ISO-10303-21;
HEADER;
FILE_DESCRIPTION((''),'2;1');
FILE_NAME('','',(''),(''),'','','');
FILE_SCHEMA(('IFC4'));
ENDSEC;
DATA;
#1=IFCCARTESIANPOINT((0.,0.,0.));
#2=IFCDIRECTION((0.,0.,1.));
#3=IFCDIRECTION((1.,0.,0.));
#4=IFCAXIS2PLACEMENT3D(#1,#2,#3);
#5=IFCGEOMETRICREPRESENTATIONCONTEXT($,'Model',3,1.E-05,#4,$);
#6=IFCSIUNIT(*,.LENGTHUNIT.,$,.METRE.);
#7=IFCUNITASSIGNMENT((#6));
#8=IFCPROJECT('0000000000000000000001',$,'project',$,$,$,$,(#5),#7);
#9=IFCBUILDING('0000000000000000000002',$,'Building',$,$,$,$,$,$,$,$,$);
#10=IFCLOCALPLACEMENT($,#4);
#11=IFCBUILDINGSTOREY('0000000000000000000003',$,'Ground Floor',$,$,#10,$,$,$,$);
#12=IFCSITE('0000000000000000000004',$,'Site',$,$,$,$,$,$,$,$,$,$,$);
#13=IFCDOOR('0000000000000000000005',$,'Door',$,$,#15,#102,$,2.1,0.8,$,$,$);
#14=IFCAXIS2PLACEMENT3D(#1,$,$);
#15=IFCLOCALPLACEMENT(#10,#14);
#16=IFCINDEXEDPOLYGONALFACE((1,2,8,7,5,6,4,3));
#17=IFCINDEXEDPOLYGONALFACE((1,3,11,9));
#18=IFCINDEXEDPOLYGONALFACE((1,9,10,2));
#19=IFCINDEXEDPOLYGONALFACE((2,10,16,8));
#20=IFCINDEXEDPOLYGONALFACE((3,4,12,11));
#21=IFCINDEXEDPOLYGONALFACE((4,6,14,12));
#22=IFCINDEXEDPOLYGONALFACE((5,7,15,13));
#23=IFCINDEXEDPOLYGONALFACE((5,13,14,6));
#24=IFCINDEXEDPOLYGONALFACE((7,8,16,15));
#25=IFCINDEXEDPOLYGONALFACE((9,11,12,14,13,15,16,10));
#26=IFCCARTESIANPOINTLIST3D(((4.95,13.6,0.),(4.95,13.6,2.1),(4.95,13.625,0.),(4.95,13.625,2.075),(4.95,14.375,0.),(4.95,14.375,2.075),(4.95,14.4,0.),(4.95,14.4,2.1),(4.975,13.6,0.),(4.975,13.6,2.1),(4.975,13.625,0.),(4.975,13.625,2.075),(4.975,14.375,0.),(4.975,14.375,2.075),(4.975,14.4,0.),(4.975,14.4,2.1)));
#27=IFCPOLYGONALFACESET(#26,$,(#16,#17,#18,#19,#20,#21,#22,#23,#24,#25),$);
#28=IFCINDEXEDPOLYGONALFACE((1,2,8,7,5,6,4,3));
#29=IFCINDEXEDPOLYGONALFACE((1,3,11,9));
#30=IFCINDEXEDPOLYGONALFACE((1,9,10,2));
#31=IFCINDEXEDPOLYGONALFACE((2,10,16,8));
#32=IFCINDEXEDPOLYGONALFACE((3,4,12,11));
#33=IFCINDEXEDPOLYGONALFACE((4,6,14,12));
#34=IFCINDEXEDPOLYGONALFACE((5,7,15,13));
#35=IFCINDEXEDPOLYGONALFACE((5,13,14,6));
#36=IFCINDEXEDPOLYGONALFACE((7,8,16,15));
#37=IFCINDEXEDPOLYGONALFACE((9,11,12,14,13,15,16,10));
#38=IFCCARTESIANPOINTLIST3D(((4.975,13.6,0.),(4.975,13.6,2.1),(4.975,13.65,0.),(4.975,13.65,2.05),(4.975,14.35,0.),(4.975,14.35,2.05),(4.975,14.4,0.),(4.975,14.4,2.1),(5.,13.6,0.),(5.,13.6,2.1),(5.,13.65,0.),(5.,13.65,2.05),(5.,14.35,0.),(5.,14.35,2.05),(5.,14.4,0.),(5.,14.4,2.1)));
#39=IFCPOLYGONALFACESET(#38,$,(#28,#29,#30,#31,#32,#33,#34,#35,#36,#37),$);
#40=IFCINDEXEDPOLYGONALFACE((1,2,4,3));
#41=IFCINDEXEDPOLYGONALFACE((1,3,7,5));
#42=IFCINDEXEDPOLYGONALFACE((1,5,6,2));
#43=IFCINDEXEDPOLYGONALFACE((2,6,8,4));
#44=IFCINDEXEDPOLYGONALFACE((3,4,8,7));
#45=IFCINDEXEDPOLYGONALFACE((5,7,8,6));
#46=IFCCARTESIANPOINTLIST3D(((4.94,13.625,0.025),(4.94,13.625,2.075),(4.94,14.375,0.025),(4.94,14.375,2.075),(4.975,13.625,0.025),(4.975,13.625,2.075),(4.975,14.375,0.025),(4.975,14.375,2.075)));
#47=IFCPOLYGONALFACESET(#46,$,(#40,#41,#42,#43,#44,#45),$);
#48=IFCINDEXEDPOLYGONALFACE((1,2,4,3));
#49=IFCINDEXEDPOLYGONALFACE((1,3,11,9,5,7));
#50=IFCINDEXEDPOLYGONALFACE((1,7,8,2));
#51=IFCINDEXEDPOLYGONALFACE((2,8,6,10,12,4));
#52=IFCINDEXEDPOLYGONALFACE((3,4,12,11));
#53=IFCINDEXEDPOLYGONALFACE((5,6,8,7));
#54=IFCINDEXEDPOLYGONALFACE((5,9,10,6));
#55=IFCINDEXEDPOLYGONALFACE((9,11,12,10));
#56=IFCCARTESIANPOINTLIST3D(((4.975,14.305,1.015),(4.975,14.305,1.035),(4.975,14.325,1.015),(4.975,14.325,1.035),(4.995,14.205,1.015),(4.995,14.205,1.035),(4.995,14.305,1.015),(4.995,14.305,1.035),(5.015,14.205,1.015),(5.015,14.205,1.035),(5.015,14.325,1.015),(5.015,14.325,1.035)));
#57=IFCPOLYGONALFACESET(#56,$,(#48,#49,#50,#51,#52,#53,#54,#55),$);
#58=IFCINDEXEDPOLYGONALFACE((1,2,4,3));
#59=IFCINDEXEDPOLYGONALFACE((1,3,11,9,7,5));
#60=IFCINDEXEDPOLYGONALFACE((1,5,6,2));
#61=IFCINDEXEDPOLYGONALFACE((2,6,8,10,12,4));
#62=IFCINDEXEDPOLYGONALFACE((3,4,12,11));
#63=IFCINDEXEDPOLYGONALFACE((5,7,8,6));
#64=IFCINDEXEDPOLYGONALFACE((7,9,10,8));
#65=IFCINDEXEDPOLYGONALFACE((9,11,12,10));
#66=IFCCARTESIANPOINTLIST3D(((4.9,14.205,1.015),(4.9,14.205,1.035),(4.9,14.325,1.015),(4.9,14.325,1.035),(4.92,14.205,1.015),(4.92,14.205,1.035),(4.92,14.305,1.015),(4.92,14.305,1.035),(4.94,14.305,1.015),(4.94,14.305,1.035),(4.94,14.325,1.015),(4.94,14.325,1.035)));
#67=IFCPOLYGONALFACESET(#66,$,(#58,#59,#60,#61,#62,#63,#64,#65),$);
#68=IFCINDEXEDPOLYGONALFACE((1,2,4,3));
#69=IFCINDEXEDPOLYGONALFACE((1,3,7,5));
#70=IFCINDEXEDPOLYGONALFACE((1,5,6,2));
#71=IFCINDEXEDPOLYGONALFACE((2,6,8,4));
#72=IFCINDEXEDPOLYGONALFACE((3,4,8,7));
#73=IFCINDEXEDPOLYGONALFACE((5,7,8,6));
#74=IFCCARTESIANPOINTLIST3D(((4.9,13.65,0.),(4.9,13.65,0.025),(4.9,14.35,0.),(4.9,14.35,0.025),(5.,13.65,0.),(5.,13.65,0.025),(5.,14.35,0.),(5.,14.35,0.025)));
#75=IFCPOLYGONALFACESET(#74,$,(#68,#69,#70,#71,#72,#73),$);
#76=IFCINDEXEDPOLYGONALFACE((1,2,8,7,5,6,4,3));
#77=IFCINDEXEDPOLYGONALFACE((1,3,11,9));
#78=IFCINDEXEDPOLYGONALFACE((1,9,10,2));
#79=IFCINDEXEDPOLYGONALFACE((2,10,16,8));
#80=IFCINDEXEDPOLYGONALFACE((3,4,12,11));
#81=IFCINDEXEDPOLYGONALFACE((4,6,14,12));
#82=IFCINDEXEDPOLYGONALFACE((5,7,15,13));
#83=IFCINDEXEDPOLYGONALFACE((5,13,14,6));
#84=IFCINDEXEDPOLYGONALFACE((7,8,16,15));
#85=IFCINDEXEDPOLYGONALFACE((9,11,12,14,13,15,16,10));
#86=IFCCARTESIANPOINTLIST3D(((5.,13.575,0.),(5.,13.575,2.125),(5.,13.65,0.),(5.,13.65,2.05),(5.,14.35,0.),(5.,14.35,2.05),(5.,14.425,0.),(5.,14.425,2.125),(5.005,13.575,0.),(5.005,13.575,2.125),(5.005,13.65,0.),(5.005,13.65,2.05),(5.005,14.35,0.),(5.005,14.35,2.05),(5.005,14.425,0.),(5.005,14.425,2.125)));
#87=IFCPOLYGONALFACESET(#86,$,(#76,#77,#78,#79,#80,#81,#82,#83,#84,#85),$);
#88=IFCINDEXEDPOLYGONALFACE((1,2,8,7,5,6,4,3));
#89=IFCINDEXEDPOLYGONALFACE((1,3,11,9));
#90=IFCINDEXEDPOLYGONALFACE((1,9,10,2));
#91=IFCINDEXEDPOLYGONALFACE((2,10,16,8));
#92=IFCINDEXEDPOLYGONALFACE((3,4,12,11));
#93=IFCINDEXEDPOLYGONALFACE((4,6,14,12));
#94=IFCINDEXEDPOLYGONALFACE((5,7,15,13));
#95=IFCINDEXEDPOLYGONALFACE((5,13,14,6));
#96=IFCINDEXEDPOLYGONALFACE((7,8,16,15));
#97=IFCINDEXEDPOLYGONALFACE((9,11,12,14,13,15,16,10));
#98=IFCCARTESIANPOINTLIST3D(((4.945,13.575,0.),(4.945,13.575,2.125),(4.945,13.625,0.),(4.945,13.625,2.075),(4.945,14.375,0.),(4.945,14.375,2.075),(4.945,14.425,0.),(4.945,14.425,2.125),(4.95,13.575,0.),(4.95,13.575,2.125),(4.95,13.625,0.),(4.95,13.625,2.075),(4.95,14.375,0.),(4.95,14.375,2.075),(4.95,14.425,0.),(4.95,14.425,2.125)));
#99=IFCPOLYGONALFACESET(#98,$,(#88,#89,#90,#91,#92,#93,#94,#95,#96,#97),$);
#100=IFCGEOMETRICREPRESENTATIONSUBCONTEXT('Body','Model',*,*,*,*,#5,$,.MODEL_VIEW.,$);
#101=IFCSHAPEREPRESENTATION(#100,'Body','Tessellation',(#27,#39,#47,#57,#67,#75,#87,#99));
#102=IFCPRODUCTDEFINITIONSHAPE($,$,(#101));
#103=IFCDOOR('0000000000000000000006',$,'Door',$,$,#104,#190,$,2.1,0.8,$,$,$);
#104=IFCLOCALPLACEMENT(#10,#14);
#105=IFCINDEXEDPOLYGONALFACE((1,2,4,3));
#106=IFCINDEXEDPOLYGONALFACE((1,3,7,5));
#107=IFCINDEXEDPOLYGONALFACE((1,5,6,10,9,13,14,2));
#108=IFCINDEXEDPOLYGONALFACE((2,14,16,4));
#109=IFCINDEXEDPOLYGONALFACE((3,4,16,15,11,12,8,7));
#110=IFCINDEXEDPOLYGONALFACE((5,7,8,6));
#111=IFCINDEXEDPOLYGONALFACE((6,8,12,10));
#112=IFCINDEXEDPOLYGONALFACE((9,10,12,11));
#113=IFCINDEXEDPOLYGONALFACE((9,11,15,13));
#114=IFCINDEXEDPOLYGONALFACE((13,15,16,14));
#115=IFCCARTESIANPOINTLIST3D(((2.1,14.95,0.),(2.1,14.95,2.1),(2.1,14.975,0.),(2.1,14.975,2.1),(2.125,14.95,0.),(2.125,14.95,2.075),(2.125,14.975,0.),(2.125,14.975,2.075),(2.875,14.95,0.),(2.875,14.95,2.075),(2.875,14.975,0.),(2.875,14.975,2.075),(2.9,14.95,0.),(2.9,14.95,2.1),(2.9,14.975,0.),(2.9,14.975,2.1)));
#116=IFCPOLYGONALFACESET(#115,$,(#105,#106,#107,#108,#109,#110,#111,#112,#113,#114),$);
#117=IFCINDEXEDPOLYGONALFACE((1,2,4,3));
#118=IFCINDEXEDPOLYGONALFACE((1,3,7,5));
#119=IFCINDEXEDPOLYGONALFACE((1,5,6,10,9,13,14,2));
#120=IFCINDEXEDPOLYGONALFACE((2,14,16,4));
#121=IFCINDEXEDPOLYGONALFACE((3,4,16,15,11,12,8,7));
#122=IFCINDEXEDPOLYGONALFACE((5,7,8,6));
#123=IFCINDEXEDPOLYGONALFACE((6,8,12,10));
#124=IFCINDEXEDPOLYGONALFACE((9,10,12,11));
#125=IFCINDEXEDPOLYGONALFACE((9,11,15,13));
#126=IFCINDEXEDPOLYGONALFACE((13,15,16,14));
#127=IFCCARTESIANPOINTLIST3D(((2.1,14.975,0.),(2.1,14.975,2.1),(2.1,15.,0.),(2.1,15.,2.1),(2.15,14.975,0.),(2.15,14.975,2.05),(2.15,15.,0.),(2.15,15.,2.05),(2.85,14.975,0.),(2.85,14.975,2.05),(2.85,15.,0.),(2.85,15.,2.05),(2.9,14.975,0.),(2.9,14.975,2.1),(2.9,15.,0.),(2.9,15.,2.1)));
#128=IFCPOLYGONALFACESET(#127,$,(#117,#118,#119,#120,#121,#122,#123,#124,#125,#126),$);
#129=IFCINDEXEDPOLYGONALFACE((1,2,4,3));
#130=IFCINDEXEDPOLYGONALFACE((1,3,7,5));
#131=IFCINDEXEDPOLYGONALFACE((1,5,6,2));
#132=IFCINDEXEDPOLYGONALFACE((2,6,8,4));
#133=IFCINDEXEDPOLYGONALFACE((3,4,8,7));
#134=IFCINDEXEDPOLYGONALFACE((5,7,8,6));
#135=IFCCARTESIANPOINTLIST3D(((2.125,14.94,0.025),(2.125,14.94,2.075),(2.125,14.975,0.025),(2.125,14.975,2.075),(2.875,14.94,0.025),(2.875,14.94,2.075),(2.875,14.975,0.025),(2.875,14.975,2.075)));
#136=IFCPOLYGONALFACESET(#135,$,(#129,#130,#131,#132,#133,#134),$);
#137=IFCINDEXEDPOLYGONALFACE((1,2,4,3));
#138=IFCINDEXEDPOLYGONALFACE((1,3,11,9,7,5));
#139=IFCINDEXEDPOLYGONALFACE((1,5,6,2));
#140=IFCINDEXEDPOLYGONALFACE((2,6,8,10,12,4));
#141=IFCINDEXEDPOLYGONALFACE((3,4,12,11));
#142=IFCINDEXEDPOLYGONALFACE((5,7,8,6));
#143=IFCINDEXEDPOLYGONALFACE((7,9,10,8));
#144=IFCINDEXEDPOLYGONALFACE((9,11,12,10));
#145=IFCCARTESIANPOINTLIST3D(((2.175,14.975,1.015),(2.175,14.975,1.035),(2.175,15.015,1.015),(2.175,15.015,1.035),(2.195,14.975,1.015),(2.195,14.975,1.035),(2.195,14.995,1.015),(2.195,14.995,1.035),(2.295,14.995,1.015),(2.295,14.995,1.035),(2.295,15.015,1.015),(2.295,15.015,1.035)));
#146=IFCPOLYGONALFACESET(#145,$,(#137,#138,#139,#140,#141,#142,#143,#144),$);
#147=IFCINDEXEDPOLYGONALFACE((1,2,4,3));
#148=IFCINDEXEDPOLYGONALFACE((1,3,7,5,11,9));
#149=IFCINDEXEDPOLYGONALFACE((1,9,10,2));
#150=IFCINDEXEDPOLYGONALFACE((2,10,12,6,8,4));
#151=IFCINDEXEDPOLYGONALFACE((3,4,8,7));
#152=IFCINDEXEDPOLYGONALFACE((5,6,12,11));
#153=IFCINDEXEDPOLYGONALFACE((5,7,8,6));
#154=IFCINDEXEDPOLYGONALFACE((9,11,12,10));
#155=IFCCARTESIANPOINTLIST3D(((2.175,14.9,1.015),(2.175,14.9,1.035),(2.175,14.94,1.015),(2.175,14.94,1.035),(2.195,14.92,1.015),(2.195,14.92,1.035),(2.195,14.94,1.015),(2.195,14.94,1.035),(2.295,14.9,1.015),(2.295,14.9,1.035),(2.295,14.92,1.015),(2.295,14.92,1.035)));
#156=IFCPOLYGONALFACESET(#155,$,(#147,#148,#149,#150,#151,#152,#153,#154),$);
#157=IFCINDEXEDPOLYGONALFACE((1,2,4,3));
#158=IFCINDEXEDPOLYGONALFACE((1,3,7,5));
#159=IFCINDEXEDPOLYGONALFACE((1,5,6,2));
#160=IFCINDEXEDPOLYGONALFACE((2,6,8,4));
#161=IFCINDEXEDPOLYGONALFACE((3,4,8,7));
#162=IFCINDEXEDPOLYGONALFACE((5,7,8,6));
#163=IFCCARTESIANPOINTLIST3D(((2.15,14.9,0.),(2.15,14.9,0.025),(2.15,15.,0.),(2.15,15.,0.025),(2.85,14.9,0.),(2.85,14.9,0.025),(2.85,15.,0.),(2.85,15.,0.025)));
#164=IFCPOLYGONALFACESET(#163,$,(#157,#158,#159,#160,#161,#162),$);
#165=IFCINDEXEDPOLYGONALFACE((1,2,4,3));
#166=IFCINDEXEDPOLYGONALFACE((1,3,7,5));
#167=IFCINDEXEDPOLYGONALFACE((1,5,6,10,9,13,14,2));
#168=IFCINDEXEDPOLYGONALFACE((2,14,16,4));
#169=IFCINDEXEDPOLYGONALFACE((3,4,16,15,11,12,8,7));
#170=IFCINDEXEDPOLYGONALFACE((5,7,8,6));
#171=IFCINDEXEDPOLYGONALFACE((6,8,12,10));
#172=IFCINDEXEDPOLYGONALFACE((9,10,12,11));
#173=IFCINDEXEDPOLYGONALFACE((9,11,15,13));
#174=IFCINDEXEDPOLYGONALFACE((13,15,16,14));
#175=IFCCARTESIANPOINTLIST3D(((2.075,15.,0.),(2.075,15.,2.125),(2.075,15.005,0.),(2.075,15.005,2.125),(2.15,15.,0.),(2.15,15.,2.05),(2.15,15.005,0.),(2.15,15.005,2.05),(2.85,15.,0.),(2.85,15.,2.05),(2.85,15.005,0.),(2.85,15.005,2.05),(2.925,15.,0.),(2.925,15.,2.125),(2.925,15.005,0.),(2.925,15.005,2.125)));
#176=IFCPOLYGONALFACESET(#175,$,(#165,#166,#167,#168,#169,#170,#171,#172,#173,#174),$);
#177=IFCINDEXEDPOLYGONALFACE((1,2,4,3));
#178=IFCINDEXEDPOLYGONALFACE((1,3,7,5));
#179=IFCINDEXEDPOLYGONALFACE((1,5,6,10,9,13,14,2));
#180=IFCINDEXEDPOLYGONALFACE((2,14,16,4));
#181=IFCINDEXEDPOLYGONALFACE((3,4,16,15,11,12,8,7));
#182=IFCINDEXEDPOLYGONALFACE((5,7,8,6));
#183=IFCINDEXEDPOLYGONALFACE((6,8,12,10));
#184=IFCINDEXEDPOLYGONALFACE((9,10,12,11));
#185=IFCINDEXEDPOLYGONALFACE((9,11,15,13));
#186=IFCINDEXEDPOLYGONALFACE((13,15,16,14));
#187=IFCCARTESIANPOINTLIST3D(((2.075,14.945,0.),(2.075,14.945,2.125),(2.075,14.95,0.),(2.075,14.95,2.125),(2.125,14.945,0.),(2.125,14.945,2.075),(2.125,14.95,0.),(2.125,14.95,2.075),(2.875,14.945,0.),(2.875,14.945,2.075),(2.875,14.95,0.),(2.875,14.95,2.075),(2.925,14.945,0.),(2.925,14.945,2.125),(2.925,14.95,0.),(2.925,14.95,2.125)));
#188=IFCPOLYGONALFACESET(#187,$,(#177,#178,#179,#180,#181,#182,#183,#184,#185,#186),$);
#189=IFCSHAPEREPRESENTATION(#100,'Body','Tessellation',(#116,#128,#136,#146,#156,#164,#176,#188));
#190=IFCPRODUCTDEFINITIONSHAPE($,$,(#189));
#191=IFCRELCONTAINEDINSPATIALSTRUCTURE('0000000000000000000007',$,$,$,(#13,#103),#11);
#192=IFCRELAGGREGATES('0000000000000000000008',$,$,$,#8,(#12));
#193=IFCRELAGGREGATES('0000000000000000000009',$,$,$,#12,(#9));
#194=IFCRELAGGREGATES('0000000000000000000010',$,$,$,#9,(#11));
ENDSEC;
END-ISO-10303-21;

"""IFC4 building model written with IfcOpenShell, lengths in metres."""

from ifc_helpers import new_model, si_unit, frame, origin_with_axes, place, context, subcontext, project, spatial, line, indexed_curve, outline, extrude, element, save


model = new_model("IFC4")

# Units and contexts
model_context = context("Model", 3, precision=1e-05, world=origin_with_axes())
body_context = subcontext(model_context, "Body", "Model", "MODEL_VIEW")
ifc_project = project(units=[si_unit("LENGTHUNIT", "METRE")], contexts=[model_context])

# Site, building, storey
site = spatial("IfcSite", under=ifc_project, Name="Site")
building = spatial("IfcBuilding", under=site, Name="Building")
storey_placement = place(None, origin_with_axes())
storey = spatial("IfcBuildingStorey", under=building, at=storey_placement, Name="Ground Floor")

# Doors
door_1_placement = place(storey_placement, frame((5.0, 13.6, 0.0), z_axis=(0.0, 0.0, 1.0), x_axis=(0.0, 1.0, 0.0)))
element("IfcDoor", 1, at=door_1_placement, inside=storey, Name="Door", OverallHeight=2.1, OverallWidth=0.8, context=body_context, shape_type="SweptSolid", body=[
    extrude(outline(indexed_curve([(0.0, 0.0), (0.0, 2.1), (0.8, 2.1), (0.8, 0.0), (0.775, 0.0), (0.775, 2.075), (0.025, 2.075), (0.025, 0.0)], segments=[line(1, 2, 3, 4, 5, 6, 7, 8, 1)])), frame((0.0, 0.025, 0.0), z_axis=(0.0, -1.0, 0.0), x_axis=(1.0, 0.0, 0.0)), (0.0, 0.0, -1.0), 0.025),
    extrude(outline(indexed_curve([(0.0, 0.0), (0.0, 2.1), (0.8, 2.1), (0.8, 0.0), (0.75, 0.0), (0.75, 2.05), (0.05, 2.05), (0.05, 0.0)], segments=[line(1, 2, 3, 4, 5, 6, 7, 8, 1)])), frame((0.0, 0.0, 0.0), z_axis=(0.0, -1.0, 0.0), x_axis=(1.0, 0.0, 0.0)), (0.0, 0.0, -1.0), 0.025),
    extrude(outline(indexed_curve([(0.0, 0.0), (0.75, 0.0), (0.75, 0.035), (0.0, 0.035)], segments=[line(1, 2, 3, 4, 1)])), frame((0.025, 0.025, 0.025), z_axis=(0.0, 0.0, 1.0), x_axis=(1.0, 0.0, 0.0)), (0.0, 0.0, 1.0), 2.05),
    extrude(outline(indexed_curve([(0.0, 0.0), (0.0, -0.04), (-0.12, -0.04), (-0.12, -0.02), (-0.02, -0.02), (-0.02, 0.0)], segments=[line(1, 2, 3, 4, 5, 6, 1)])), frame((0.725, 0.025, 1.015), z_axis=(0.0, 0.0, 1.0), x_axis=(1.0, 0.0, 0.0)), (0.0, 0.0, 1.0), 0.02),
    extrude(outline(indexed_curve([(0.0, 0.0), (0.0, 0.04), (-0.12, 0.04), (-0.12, 0.02), (-0.02, 0.02), (-0.02, 0.0)], segments=[line(1, 2, 3, 4, 5, 6, 1)])), frame((0.725, 0.06, 1.015), z_axis=(0.0, 0.0, 1.0), x_axis=(1.0, 0.0, 0.0)), (0.0, 0.0, 1.0), 0.02),
    extrude(outline(indexed_curve([(0.0, 0.0), (0.7, 0.0), (0.7, 0.1), (0.0, 0.1)], segments=[line(1, 2, 3, 4, 1)])), frame((0.05, 0.0, 0.0), z_axis=(0.0, 0.0, 1.0), x_axis=(1.0, 0.0, 0.0)), (0.0, 0.0, 1.0), 0.025),
    extrude(outline(indexed_curve([(0.0, 0.0), (0.0, 2.125), (0.85, 2.125), (0.85, 0.0), (0.775, 0.0), (0.775, 2.05), (0.075, 2.05), (0.075, 0.0)], segments=[line(1, 2, 3, 4, 5, 6, 7, 8, 1)])), frame((-0.025, -0.005, 0.0), z_axis=(0.0, -1.0, 0.0), x_axis=(1.0, 0.0, 0.0)), (0.0, 0.0, -1.0), 0.005),
    extrude(outline(indexed_curve([(0.0, 0.0), (0.0, 2.125), (0.85, 2.125), (0.85, 0.0), (0.8, 0.0), (0.8, 2.075), (0.05, 2.075), (0.05, 0.0)], segments=[line(1, 2, 3, 4, 5, 6, 7, 8, 1)])), frame((-0.025, 0.05, 0.0), z_axis=(0.0, -1.0, 0.0), x_axis=(1.0, 0.0, 0.0)), (0.0, 0.0, -1.0), 0.005),
])
door_2_placement = place(storey_placement, frame((2.9, 15.0, 0.0), z_axis=(0.0, 0.0, 1.0), x_axis=(-1.0, 0.0, 0.0)))
element("IfcDoor", 2, at=door_2_placement, inside=storey, Name="Door", OverallHeight=2.1, OverallWidth=0.8, context=body_context, shape_type="SweptSolid", body=[
    extrude(outline(indexed_curve([(0.0, 0.0), (0.0, 2.1), (0.8, 2.1), (0.8, 0.0), (0.775, 0.0), (0.775, 2.075), (0.025, 2.075), (0.025, 0.0)], segments=[line(1, 2, 3, 4, 5, 6, 7, 8, 1)])), frame((0.0, 0.025, 0.0), z_axis=(0.0, -1.0, 0.0), x_axis=(1.0, 0.0, 0.0)), (0.0, 0.0, -1.0), 0.025),
    extrude(outline(indexed_curve([(0.0, 0.0), (0.0, 2.1), (0.8, 2.1), (0.8, 0.0), (0.75, 0.0), (0.75, 2.05), (0.05, 2.05), (0.05, 0.0)], segments=[line(1, 2, 3, 4, 5, 6, 7, 8, 1)])), frame((0.0, 0.0, 0.0), z_axis=(0.0, -1.0, 0.0), x_axis=(1.0, 0.0, 0.0)), (0.0, 0.0, -1.0), 0.025),
    extrude(outline(indexed_curve([(0.0, 0.0), (0.75, 0.0), (0.75, 0.035), (0.0, 0.035)], segments=[line(1, 2, 3, 4, 1)])), frame((0.025, 0.025, 0.025), z_axis=(0.0, 0.0, 1.0), x_axis=(1.0, 0.0, 0.0)), (0.0, 0.0, 1.0), 2.05),
    extrude(outline(indexed_curve([(0.0, 0.0), (0.0, -0.04), (-0.12, -0.04), (-0.12, -0.02), (-0.02, -0.02), (-0.02, 0.0)], segments=[line(1, 2, 3, 4, 5, 6, 1)])), frame((0.725, 0.025, 1.015), z_axis=(0.0, 0.0, 1.0), x_axis=(1.0, 0.0, 0.0)), (0.0, 0.0, 1.0), 0.02),
    extrude(outline(indexed_curve([(0.0, 0.0), (0.0, 0.04), (-0.12, 0.04), (-0.12, 0.02), (-0.02, 0.02), (-0.02, 0.0)], segments=[line(1, 2, 3, 4, 5, 6, 1)])), frame((0.725, 0.06, 1.015), z_axis=(0.0, 0.0, 1.0), x_axis=(1.0, 0.0, 0.0)), (0.0, 0.0, 1.0), 0.02),
    extrude(outline(indexed_curve([(0.0, 0.0), (0.7, 0.0), (0.7, 0.1), (0.0, 0.1)], segments=[line(1, 2, 3, 4, 1)])), frame((0.05, 0.0, 0.0), z_axis=(0.0, 0.0, 1.0), x_axis=(1.0, 0.0, 0.0)), (0.0, 0.0, 1.0), 0.025),
    extrude(outline(indexed_curve([(0.0, 0.0), (0.0, 2.125), (0.85, 2.125), (0.85, 0.0), (0.775, 0.0), (0.775, 2.05), (0.075, 2.05), (0.075, 0.0)], segments=[line(1, 2, 3, 4, 5, 6, 7, 8, 1)])), frame((-0.025, -0.005, 0.0), z_axis=(0.0, -1.0, 0.0), x_axis=(1.0, 0.0, 0.0)), (0.0, 0.0, -1.0), 0.005),
    extrude(outline(indexed_curve([(0.0, 0.0), (0.0, 2.125), (0.85, 2.125), (0.85, 0.0), (0.8, 0.0), (0.8, 2.075), (0.05, 2.075), (0.05, 0.0)], segments=[line(1, 2, 3, 4, 5, 6, 7, 8, 1)])), frame((-0.025, 0.05, 0.0), z_axis=(0.0, -1.0, 0.0), x_axis=(1.0, 0.0, 0.0)), (0.0, 0.0, -1.0), 0.005),
])

save(model, "model.ifc")
